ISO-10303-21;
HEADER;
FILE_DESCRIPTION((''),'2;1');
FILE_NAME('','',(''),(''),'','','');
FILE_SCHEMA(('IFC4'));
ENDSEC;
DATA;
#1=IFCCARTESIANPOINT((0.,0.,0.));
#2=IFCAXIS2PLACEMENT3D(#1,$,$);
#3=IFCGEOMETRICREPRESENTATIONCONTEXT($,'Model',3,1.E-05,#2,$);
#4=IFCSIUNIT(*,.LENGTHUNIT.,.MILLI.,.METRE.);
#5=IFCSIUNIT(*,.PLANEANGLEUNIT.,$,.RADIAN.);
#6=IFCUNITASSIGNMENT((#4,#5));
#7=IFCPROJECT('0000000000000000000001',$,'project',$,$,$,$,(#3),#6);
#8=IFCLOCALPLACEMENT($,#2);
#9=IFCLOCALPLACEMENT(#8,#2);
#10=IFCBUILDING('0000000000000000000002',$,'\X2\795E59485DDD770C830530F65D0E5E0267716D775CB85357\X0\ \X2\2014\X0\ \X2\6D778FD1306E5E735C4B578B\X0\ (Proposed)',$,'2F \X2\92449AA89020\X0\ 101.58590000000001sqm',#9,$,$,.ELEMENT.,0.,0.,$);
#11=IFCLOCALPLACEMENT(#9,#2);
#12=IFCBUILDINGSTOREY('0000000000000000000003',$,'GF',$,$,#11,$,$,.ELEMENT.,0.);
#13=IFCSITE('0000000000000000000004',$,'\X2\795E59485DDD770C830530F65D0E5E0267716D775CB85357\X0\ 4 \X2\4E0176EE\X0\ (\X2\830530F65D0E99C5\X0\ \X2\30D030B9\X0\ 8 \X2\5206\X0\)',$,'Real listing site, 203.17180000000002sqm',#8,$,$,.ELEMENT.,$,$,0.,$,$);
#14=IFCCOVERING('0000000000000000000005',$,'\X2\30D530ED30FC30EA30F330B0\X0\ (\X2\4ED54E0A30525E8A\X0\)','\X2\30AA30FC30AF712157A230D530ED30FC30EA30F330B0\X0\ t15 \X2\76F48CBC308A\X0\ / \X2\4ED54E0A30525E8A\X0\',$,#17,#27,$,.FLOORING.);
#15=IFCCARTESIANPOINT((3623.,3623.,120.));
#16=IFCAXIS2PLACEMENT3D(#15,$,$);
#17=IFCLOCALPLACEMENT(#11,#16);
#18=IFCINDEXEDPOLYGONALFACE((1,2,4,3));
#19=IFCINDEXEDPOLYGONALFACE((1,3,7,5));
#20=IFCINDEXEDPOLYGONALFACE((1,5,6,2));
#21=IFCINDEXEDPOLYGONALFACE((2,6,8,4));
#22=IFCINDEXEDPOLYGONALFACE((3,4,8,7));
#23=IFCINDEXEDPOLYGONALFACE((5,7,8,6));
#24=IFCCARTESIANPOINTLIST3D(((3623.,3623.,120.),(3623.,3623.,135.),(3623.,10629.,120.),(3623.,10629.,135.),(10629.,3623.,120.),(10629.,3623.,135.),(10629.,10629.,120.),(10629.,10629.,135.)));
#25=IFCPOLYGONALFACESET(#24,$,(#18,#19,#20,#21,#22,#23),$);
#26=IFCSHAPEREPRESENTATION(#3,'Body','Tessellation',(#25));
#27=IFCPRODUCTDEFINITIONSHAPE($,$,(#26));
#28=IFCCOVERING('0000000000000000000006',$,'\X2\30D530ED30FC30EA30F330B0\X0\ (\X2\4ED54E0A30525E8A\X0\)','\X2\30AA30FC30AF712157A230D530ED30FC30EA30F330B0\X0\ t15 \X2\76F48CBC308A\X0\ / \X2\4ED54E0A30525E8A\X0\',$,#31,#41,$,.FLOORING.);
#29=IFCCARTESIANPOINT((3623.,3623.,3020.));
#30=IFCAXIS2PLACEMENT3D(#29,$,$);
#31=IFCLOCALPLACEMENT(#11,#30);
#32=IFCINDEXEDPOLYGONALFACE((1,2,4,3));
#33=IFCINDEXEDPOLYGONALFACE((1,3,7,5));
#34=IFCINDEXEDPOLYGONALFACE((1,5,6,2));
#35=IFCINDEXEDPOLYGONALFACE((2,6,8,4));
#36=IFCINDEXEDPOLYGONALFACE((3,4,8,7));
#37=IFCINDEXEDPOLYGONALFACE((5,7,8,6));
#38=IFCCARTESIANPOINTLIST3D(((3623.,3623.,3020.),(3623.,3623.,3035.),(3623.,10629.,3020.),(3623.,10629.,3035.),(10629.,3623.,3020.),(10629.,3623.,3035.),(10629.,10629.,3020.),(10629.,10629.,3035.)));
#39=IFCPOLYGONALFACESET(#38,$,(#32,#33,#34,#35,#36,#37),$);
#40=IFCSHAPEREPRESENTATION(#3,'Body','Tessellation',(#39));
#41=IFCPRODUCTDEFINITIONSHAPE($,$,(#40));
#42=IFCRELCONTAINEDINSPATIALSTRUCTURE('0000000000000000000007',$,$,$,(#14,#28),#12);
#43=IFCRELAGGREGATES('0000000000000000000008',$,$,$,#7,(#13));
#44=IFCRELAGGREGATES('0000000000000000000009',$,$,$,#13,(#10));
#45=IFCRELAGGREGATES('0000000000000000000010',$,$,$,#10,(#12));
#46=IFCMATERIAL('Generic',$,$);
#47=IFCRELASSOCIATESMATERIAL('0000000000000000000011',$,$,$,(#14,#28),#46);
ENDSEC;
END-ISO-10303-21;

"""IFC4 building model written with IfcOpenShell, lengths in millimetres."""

from ifc_helpers import new_model, si_unit, frame, frame_2d, origin, place, context, project, spatial, rectangle, extrude, material, element, save


model = new_model("IFC4")

# Units and contexts
model_context = context("Model", 3, precision=1e-05, world=origin())
ifc_project = project(units=[si_unit("LENGTHUNIT", "METRE", prefix="MILLI"), si_unit("PLANEANGLEUNIT", "RADIAN")], contexts=[model_context])

# Site, building, storey
site_placement = place(None, origin())
site = spatial("IfcSite", under=ifc_project, at=site_placement, Name="神奈川県茅ヶ崎市東海岸南 4 丁目 (茅ヶ崎駅 バス 8 分)", ObjectType="Real listing site, 203.17180000000002sqm", CompositionType="ELEMENT", RefElevation=0.0)
building_placement = place(site_placement, origin())
building = spatial("IfcBuilding", under=site, at=building_placement, Name="神奈川県茅ヶ崎市東海岸南 — 海近の平屋型 (Proposed)", ObjectType="2F 鉄骨造 101.58590000000001sqm", CompositionType="ELEMENT", ElevationOfRefHeight=0.0, ElevationOfTerrain=0.0)
storey_placement = place(building_placement, origin())
storey = spatial("IfcBuildingStorey", under=building, at=storey_placement, Name="GF", CompositionType="ELEMENT", Elevation=0.0)

# Coverings
ifc_material_1 = material(Name="Generic")
covering_1_placement = place(storey_placement, frame((3623.0, 3623.0, 120.0)))
element("IfcCovering", 1, at=covering_1_placement, inside=storey, material=ifc_material_1, Name="フローリング (仕上げ床)", Description="オーク無垢フローリング t15 直貼り / 仕上げ床", PredefinedType="FLOORING", context=model_context, shape_type="SweptSolid", body=[
    extrude(rectangle(XDim=7006.0, YDim=7006.0, at=frame_2d((3503.0, 3503.0))), frame((3623.0, 3623.0, 120.0)), (0.0, 0.0, 1.0), 15.0),
])
covering_2_placement = place(storey_placement, frame((3623.0, 3623.0, 3020.0)))
element("IfcCovering", 2, at=covering_2_placement, inside=storey, material=ifc_material_1, Name="フローリング (仕上げ床)", Description="オーク無垢フローリング t15 直貼り / 仕上げ床", PredefinedType="FLOORING", context=model_context, shape_type="SweptSolid", body=[
    extrude(rectangle(XDim=7006.0, YDim=7006.0, at=frame_2d((3503.0, 3503.0))), frame((3623.0, 3623.0, 3020.0)), (0.0, 0.0, 1.0), 15.0),
])

save(model, "model.ifc")
